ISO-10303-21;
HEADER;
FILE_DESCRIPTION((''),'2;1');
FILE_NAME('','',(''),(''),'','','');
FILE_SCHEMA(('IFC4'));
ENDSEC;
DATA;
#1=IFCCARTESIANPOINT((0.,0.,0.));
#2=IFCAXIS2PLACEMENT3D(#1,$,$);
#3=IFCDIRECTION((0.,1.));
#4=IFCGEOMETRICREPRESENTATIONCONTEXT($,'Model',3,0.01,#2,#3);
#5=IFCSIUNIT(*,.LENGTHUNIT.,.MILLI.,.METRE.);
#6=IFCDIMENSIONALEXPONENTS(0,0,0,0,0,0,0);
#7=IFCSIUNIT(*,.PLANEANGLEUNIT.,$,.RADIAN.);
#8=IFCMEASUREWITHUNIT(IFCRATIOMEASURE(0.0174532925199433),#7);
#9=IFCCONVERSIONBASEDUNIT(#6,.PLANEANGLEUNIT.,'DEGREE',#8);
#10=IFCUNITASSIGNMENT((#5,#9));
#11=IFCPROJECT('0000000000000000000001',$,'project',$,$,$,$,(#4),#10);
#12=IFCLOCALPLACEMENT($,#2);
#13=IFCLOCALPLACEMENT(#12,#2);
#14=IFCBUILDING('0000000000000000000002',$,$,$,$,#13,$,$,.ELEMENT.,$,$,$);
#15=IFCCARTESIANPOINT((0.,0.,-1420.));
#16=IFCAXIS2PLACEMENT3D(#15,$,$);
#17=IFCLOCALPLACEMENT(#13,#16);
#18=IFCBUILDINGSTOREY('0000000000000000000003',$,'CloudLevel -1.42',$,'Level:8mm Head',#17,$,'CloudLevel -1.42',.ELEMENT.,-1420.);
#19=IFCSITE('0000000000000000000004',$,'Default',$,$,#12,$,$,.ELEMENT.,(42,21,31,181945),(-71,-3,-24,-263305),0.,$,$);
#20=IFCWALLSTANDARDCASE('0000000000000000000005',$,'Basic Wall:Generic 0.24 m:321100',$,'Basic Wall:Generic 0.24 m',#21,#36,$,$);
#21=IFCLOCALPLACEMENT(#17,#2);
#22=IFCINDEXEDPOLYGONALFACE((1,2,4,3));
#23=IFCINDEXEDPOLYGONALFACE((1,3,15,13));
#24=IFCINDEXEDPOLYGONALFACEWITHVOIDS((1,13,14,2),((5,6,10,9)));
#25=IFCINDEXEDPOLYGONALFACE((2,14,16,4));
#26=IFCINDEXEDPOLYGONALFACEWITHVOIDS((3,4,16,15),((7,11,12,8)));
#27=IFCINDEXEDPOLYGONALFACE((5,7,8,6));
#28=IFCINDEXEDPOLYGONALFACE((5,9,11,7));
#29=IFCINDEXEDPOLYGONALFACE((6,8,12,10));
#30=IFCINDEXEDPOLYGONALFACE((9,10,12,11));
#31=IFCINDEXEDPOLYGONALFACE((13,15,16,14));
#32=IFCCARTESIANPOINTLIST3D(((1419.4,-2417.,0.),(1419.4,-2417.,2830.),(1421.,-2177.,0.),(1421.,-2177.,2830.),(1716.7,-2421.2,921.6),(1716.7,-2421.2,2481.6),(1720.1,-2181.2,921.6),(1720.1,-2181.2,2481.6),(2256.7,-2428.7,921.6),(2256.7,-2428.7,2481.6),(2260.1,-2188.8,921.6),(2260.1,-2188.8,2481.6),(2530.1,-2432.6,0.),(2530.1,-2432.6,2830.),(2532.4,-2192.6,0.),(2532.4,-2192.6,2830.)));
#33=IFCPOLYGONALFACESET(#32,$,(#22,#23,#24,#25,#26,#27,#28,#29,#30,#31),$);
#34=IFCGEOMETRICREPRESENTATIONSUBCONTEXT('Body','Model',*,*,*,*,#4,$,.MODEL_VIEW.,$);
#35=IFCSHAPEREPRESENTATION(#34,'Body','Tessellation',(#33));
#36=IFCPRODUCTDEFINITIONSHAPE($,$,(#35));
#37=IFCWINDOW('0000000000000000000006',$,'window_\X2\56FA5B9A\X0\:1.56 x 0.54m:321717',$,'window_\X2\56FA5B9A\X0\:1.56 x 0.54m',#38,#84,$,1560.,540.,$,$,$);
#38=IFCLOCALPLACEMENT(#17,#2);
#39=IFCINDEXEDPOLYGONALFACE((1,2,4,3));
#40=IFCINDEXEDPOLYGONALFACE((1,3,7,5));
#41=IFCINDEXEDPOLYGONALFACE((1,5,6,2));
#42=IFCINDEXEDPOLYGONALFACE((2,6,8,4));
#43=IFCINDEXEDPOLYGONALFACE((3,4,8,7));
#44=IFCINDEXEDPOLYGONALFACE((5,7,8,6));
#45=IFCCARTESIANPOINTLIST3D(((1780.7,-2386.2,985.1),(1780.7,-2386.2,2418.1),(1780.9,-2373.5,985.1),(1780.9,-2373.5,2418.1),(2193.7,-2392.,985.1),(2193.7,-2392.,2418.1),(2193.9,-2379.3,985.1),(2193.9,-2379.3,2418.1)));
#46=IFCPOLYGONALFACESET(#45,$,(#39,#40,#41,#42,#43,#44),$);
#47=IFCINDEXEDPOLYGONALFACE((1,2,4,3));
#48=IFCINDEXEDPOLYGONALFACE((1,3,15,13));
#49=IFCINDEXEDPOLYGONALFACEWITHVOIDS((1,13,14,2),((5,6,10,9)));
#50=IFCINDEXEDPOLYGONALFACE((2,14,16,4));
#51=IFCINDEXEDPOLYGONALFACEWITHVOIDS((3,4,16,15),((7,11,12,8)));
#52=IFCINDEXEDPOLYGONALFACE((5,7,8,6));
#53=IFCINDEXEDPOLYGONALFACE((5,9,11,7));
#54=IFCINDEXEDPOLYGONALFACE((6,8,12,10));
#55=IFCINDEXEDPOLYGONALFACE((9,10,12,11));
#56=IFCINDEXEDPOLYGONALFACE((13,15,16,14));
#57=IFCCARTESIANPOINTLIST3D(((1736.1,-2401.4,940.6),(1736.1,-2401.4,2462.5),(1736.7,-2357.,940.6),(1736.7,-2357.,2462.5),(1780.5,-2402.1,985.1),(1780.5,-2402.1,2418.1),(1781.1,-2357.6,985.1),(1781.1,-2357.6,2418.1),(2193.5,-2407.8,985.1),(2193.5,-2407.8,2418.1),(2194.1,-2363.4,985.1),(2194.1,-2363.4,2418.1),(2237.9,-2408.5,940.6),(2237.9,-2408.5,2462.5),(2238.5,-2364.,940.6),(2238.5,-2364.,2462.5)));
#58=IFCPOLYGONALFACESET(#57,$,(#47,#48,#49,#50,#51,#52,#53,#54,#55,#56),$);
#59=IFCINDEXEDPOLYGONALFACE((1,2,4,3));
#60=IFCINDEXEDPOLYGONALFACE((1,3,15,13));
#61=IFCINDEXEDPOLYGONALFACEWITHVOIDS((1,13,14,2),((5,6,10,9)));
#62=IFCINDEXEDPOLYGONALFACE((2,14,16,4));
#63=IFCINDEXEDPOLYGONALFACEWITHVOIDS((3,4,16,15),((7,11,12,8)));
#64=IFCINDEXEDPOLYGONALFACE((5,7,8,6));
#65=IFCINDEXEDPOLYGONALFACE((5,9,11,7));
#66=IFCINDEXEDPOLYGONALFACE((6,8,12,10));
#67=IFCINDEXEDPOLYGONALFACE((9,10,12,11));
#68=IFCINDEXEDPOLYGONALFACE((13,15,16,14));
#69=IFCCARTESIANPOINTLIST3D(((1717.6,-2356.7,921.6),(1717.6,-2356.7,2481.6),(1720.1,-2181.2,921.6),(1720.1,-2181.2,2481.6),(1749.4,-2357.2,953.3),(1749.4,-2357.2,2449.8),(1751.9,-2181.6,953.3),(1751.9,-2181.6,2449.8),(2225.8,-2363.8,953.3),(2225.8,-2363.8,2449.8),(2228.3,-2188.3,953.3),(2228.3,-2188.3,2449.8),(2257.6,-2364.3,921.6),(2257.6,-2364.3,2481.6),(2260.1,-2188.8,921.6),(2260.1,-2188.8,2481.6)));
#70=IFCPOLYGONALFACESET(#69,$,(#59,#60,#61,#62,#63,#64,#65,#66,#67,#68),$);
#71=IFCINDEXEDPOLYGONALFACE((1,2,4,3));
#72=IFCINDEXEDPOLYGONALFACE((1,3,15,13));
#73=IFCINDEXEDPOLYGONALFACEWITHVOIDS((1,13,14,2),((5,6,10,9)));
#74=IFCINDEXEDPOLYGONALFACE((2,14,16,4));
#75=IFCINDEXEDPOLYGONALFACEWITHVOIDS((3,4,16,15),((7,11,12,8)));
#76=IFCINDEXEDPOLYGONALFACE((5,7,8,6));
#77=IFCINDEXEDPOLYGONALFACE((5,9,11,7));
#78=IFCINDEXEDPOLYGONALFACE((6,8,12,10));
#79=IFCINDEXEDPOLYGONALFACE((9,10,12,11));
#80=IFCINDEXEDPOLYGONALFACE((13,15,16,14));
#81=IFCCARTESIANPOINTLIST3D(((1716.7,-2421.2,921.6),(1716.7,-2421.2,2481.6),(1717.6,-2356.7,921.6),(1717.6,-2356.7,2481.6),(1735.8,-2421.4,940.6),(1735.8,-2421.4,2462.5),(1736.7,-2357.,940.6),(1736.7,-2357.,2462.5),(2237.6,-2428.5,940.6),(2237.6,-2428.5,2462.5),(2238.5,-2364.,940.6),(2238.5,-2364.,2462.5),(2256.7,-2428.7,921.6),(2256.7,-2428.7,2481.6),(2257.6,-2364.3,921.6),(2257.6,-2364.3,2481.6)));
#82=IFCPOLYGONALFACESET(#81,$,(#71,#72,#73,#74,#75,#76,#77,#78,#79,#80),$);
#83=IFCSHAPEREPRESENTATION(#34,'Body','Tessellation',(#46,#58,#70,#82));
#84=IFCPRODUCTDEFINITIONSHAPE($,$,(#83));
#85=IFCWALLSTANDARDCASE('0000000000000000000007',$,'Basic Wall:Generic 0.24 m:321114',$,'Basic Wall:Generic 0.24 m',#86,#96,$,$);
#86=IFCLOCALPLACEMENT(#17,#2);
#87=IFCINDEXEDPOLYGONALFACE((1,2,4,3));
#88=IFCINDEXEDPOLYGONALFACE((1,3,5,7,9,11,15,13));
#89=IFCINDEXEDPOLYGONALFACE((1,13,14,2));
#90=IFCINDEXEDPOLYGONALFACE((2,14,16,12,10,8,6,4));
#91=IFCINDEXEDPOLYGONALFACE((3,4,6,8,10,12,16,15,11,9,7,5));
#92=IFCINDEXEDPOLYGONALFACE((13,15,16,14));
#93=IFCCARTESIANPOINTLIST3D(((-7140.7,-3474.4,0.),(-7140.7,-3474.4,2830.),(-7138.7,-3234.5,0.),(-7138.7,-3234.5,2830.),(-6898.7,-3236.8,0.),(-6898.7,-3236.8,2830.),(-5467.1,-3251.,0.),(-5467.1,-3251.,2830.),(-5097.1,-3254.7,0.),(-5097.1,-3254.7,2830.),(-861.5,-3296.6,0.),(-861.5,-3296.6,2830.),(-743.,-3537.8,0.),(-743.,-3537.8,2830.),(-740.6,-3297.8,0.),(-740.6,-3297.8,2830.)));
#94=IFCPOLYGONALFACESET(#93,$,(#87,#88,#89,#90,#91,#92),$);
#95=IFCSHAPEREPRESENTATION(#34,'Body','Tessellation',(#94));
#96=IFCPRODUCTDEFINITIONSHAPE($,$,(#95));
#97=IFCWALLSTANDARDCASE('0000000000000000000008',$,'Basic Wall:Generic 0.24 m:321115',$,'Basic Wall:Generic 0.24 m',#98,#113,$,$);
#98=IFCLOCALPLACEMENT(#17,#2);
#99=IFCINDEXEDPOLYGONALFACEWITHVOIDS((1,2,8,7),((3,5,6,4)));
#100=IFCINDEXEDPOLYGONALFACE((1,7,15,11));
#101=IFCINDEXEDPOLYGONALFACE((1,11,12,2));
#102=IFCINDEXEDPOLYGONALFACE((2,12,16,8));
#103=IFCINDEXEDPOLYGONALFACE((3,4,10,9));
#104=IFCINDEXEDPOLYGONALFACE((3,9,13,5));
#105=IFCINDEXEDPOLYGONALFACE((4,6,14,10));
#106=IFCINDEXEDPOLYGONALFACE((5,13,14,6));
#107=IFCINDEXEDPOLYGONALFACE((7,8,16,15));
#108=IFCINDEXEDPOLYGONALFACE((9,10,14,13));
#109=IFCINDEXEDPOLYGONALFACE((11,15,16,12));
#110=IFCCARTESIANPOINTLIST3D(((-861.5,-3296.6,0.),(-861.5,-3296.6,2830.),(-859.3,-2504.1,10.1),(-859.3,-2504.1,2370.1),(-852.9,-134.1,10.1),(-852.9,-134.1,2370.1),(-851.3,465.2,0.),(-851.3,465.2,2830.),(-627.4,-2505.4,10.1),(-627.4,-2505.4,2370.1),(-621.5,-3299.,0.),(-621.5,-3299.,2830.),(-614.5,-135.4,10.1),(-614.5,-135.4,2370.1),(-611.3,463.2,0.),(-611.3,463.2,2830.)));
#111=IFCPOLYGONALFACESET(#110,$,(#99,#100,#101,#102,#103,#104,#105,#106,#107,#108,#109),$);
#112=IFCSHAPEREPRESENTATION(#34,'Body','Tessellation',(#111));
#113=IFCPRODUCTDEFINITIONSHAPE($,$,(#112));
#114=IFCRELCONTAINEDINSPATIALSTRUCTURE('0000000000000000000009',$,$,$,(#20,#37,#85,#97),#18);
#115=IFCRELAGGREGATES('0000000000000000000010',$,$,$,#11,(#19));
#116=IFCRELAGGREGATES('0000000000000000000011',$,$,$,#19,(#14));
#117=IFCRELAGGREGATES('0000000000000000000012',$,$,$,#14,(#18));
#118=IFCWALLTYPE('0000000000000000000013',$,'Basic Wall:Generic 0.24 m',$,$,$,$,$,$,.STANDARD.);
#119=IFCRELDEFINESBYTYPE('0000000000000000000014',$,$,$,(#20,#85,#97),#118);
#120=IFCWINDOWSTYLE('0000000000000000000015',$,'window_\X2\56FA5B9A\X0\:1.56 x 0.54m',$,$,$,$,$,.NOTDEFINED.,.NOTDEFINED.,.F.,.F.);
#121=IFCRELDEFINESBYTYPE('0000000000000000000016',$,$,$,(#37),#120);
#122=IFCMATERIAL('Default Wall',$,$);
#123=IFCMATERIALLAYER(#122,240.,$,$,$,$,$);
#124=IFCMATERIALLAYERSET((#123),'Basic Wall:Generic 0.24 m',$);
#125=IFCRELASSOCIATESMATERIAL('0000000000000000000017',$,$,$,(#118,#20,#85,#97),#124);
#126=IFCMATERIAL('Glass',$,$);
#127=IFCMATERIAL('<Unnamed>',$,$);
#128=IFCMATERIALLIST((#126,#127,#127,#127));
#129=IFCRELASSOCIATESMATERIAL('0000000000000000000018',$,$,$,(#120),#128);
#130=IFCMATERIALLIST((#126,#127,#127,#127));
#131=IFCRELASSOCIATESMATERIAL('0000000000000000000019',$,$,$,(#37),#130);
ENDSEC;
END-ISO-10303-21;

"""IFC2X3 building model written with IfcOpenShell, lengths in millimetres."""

from ifc_helpers import new_model, entity, si_unit, converted_unit, direction, frame, frame_2d, origin, place, context, subcontext, project, spatial, polyline, rectangle, outline, extrude, source, transform, mapped, material, material_list, layer, layer_set, layer_usage, type_object, type_shapes, element, fill, save


model = new_model("IFC2X3")

# Units and contexts
model_context = context("Model", 3, precision=0.01, world=origin(), true_north=direction((0.0, 1.0)))
body_context = subcontext(model_context, "Body", "Model", "MODEL_VIEW")
ifc_project = project(units=[si_unit("LENGTHUNIT", "METRE", prefix="MILLI"), converted_unit("PLANEANGLEUNIT", "DEGREE", entity("IfcRatioMeasure", 0.0174532925199433), si_unit("PLANEANGLEUNIT", "RADIAN"), dimensions=[0, 0, 0, 0, 0, 0, 0])], contexts=[model_context])

# Site, building, storey
site_placement = place(None, origin())
site = spatial("IfcSite", under=ifc_project, at=site_placement, Name="Default", CompositionType="ELEMENT", RefLatitude=(42, 21, 31, 181945), RefLongitude=(-71, -3, -24, -263305), RefElevation=0.0)
building_placement = place(site_placement, origin())
building = spatial("IfcBuilding", under=site, at=building_placement, CompositionType="ELEMENT")
storey_placement = place(building_placement, frame((0.0, 0.0, -1420.0)))
storey = spatial("IfcBuildingStorey", under=building, at=storey_placement, Name="CloudLevel -1.42", ObjectType="Level:8mm Head", LongName="CloudLevel -1.42", CompositionType="ELEMENT", Elevation=-1420.0)

# Shared definitions
ifc_material_1 = material(Name="Default Wall")
ifc_layer_1 = layer(ifc_material_1, 240.0)
ifc_layer_set_1 = layer_set([ifc_layer_1], Name="Basic Wall:Generic 0.24 m")
wall_type_1 = type_object("IfcWallType", Name="Basic Wall:Generic 0.24 m", PredefinedType="STANDARD", material=ifc_layer_set_1)
ifc_material_2 = material(Name="Glass")
ifc_material_3 = material(Name="<Unnamed>")

# Wall, opening, window
ifc_layer_usage_1 = layer_usage(ifc_layer_set_1, "AXIS2", "NEGATIVE", 120.0)
wall_1_placement = place(storey_placement, frame((1419.3, -2297.0, 0.0), z_axis=(0.0, 0.0, 1.0), x_axis=(0.999902, -0.013989, 0.0)))
wall_1 = element("IfcWallStandardCase", 1, at=wall_1_placement, inside=storey, type_object=wall_type_1, material=ifc_layer_usage_1, Name="Basic Wall:Generic 0.24 m:321100", ObjectType="Basic Wall:Generic 0.24 m", context=body_context, shape_type="SweptSolid", body=[
    extrude(outline(polyline([(1112.6, -120.0), (1111.4, 120.0), (0.0, 120.0), (1.7, -120.0), (1112.6, -120.0)])), origin(), (0.0, 0.0, 1.0), 2830.0),
])
opening_1_placement = place(wall_1_placement, frame((839.1, 120.0, 921.6)))
opening_1 = element("IfcOpeningElement", 2, at=opening_1_placement, cuts=wall_1, ObjectType="Opening", context=body_context, shape_type="SweptSolid", body=[
    extrude(rectangle(XDim=1560.0, YDim=540.0, at=frame_2d((780.0, 270.0), x_axis=(-1.0, 0.0))), frame((0.0, 0.0, 0.0), z_axis=(0.0, -1.0, 0.0), x_axis=(0.0, 0.0, 1.0)), (0.0, 0.0, 1.0), 240.0),
])
ifc_material_list_1 = material_list([ifc_material_2, ifc_material_3, ifc_material_3, ifc_material_3])
ifc_material_list_2 = material_list([ifc_material_2, ifc_material_3, ifc_material_3, ifc_material_3])
window_style_1 = type_object("IfcWindowStyle", Name="window_固定:1.56 x 0.54m", ConstructionType="NOTDEFINED", OperationType="NOTDEFINED", ParameterTakesPrecedence=False, Sizeable=False, material=ifc_material_list_2)
shared_shape_1 = source(origin(), body_context, "Body", "SweptSolid", [
    extrude(rectangle(XDim=413.0, YDim=12.7, at=frame_2d((0.0, 0.0), x_axis=(1.0, 0.0))), frame((346.2, 197.8, 63.5)), (0.0, 0.0, 1.0), 1433.0),
    extrude(outline(polyline([(-250.9, -760.9), (250.9, -760.9), (250.9, 760.9), (-250.9, 760.9), (-250.9, -760.9)]), holes=[polyline([(-206.5, -716.5), (-206.5, 716.5), (206.5, 716.5), (206.5, -716.5), (-206.5, -716.5)])]), frame((346.2, 220.0, 780.0), z_axis=(0.0, -1.0, 0.0), x_axis=(-1.0, 0.0, 0.0)), (0.0, 0.0, 1.0), 44.5),
    extrude(outline(polyline([(-270.0, -780.0), (270.0, -780.0), (270.0, 780.0), (-270.0, 780.0), (-270.0, -780.0)]), holes=[polyline([(-238.2, -748.2), (-238.2, 748.2), (238.2, 748.2), (238.2, -748.2), (-238.2, -748.2)])]), frame((346.2, 175.5, 780.0), z_axis=(0.0, -1.0, 0.0), x_axis=(-1.0, 0.0, 0.0)), (0.0, 0.0, 1.0), 175.5),
    extrude(outline(polyline([(-780.0, -270.0), (780.0, -270.0), (780.0, 270.0), (-780.0, 270.0), (-780.0, -270.0)]), holes=[polyline([(-760.9, -250.9), (-760.9, 250.9), (760.9, 250.9), (760.9, -250.9), (-760.9, -250.9)])]), frame((346.2, 240.0, 780.0), z_axis=(0.0, -1.0, 0.0), x_axis=(0.0, 0.0, -1.0)), (0.0, 0.0, 1.0), 64.5),
])
type_shapes(window_style_1, [shared_shape_1])
window_1_placement = place(opening_1_placement, frame((76.2, 0.0, 0.0), z_axis=(0.0, 0.0, 1.0), x_axis=(-1.0, 0.0, 0.0)))
window_1 = element("IfcWindow", 3, at=window_1_placement, inside=storey, type_object=window_style_1, material=ifc_material_list_1, Name="window_固定:1.56 x 0.54m:321717", ObjectType="window_固定:1.56 x 0.54m", OverallHeight=1560.0, OverallWidth=540.0, context=body_context, shape_type="MappedRepresentation", body=[
    mapped(shared_shape_1, transform((0.0, 0.0, 0.0), scale=1.0)),
])
fill(opening_1, window_1)

# Wall
ifc_layer_usage_2 = layer_usage(ifc_layer_set_1, "AXIS2", "NEGATIVE", 120.0)
wall_2_placement = place(storey_placement, frame((-7139.9, -3354.4, 0.0), z_axis=(0.0, 0.0, 1.0), x_axis=(0.999951, -0.009904, 0.0)))
element("IfcWallStandardCase", 4, at=wall_2_placement, inside=storey, type_object=wall_type_1, material=ifc_layer_usage_2, Name="Basic Wall:Generic 0.24 m:321114", ObjectType="Basic Wall:Generic 0.24 m", context=body_context, shape_type="SweptSolid", body=[
    extrude(outline(polyline([(6398.4, -120.0), (6398.4, 120.0), (6277.5, 120.0), (2041.7, 120.0), (1671.7, 120.0), (240.0, 120.0), (0.0, 120.0), (0.4, -120.0), (6398.4, -120.0)])), origin(), (0.0, 0.0, 1.0), 2830.0),
])

# Wall, opening
ifc_layer_usage_3 = layer_usage(ifc_layer_set_1, "AXIS2", "NEGATIVE", 120.0)
wall_3_placement = place(storey_placement, frame((-731.3, 464.8, 0.0), z_axis=(0.0, 0.0, 1.0), x_axis=(-0.002725, -0.999996, 0.0)))
wall_3 = element("IfcWallStandardCase", 5, at=wall_3_placement, inside=storey, type_object=wall_type_1, material=ifc_layer_usage_3, Name="Basic Wall:Generic 0.24 m:321115", ObjectType="Basic Wall:Generic 0.24 m", context=body_context, shape_type="SweptSolid", body=[
    extrude(outline(polyline([(3761.8, -120.0), (3762.7, 0.9), (3763.5, 120.0), (1.3, 120.0), (0.0, -120.0), (3761.8, -120.0)])), origin(), (0.0, 0.0, 1.0), 2830.0),
])
opening_2_placement = place(wall_3_placement, frame((599.3, -121.6, 10.1)))
element("IfcOpeningElement", 6, at=opening_2_placement, cuts=wall_3, ObjectType="Opening", context=body_context, shape_type="SweptSolid", body=[
    extrude(rectangle(XDim=2360.0, YDim=2370.0, at=frame_2d((1180.0, 1185.0), x_axis=(1.0, 0.0))), frame((0.0, 0.0, 0.0), z_axis=(0.002725, 0.999996, 0.0), x_axis=(0.0, 0.0, 1.0)), (0.0, 0.0, 1.0), 240.0),
])

save(model, "model.ifc")
